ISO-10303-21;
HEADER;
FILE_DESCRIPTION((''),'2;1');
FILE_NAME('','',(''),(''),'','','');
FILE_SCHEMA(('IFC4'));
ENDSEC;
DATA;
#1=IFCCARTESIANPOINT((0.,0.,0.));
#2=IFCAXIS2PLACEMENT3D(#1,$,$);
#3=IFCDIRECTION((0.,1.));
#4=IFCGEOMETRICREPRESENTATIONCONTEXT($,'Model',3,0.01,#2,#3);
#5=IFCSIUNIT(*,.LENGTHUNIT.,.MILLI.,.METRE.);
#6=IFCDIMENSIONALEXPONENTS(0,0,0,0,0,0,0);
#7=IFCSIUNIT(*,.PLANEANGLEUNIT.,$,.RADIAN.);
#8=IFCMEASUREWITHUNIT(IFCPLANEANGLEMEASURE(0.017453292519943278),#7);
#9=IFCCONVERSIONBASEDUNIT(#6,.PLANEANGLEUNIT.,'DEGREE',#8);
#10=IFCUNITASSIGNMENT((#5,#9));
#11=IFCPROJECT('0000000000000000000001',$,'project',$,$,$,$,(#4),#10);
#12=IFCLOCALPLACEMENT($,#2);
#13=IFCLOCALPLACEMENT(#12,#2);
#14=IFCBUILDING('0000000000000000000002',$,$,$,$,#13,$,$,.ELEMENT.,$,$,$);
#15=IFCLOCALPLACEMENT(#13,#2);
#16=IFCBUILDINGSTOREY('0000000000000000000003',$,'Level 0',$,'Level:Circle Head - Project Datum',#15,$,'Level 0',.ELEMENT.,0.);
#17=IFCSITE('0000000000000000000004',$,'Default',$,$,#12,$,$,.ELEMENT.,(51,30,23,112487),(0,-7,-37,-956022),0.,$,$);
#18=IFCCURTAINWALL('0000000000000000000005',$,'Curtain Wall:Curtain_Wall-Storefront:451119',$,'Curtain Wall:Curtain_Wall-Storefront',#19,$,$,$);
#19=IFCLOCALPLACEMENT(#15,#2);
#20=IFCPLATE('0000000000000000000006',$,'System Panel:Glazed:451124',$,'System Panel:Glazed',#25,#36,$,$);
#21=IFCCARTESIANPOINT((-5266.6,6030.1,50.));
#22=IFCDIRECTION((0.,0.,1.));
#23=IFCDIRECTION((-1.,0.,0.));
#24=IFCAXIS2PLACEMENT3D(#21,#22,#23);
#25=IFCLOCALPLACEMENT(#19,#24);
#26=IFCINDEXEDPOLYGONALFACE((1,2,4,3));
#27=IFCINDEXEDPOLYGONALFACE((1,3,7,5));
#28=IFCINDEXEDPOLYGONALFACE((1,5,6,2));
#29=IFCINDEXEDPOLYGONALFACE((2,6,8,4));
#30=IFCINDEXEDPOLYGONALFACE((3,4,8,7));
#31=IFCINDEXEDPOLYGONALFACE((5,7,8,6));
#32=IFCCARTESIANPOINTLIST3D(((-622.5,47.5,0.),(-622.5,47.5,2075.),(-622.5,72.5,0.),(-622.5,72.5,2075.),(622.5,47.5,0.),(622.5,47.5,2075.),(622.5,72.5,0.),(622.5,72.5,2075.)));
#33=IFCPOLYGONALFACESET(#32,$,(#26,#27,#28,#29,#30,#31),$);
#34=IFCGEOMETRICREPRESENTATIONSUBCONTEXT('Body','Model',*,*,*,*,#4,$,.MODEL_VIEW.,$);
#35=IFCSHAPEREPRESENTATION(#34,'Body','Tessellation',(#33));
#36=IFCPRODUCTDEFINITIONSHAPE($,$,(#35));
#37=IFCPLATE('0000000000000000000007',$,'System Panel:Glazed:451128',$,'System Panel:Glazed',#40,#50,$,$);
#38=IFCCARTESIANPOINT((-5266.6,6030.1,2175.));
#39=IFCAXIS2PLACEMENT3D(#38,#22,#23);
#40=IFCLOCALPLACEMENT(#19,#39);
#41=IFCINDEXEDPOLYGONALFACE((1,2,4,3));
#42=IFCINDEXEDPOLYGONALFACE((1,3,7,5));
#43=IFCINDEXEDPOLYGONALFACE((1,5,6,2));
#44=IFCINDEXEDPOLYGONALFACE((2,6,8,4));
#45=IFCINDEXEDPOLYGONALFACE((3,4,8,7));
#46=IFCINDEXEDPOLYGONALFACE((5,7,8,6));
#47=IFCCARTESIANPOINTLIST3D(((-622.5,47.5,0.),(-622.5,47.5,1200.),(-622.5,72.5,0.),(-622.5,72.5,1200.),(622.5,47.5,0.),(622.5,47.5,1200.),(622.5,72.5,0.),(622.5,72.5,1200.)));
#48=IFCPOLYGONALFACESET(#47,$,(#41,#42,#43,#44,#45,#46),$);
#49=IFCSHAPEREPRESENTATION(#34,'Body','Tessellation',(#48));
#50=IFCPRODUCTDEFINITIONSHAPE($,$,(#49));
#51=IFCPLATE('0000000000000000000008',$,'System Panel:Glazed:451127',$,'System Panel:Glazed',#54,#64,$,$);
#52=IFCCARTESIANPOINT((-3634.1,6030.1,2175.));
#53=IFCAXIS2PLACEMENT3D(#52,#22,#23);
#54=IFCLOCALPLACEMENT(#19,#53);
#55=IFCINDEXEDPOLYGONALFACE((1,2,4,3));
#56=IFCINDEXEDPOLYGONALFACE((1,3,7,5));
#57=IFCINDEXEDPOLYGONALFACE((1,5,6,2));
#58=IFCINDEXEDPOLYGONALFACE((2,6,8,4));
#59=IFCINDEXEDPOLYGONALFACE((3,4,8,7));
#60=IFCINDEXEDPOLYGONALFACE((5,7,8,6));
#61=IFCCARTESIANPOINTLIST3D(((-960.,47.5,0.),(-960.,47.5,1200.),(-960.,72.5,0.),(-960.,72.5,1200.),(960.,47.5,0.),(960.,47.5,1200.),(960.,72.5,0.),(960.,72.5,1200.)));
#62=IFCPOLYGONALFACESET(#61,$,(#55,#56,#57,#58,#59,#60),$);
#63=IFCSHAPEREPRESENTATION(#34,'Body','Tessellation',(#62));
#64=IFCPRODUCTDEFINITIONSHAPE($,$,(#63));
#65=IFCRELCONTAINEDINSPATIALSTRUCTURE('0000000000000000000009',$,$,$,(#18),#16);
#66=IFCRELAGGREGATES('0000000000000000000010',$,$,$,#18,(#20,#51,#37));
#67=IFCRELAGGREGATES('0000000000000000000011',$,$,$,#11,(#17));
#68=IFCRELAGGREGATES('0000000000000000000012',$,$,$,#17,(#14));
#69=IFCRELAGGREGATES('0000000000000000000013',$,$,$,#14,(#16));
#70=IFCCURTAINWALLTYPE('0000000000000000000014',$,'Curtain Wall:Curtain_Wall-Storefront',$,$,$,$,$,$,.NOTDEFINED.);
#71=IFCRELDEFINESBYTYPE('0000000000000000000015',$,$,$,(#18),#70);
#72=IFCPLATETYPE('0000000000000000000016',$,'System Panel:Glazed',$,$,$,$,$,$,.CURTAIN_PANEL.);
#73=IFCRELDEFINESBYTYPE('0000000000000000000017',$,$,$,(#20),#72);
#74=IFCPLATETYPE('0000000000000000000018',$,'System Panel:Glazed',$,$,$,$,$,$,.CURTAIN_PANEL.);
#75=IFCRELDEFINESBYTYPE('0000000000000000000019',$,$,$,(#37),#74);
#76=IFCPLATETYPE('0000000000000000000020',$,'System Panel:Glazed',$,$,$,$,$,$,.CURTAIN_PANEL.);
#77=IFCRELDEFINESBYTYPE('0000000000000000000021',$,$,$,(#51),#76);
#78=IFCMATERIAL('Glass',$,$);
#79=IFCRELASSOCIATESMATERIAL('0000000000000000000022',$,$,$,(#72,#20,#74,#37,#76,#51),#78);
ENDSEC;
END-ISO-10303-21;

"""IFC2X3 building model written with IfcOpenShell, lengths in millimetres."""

from ifc_helpers import new_model, entity, si_unit, converted_unit, direction, frame, origin, origin_2d_with_axis, place, context, subcontext, project, spatial, rectangle, extrude, source, transform, mapped, material, type_object, type_shapes, element, aggregate, save


model = new_model("IFC2X3")

# Units and contexts
model_context = context("Model", 3, precision=0.01, world=origin(), true_north=direction((0.0, 1.0)))
body_context = subcontext(model_context, "Body", "Model", "MODEL_VIEW")
ifc_project = project(units=[si_unit("LENGTHUNIT", "METRE", prefix="MILLI"), converted_unit("PLANEANGLEUNIT", "DEGREE", entity("IfcPlaneAngleMeasure", 0.017453292519943278), si_unit("PLANEANGLEUNIT", "RADIAN"), dimensions=[0, 0, 0, 0, 0, 0, 0])], contexts=[model_context])

# Site, building, storey
site_placement = place(None, origin())
site = spatial("IfcSite", under=ifc_project, at=site_placement, Name="Default", CompositionType="ELEMENT", RefLatitude=(51, 30, 23, 112487), RefLongitude=(0, -7, -37, -956022), RefElevation=0.0)
building_placement = place(site_placement, origin())
building = spatial("IfcBuilding", under=site, at=building_placement, CompositionType="ELEMENT")
storey_placement = place(building_placement, origin())
storey = spatial("IfcBuildingStorey", under=building, at=storey_placement, Name="Level 0", ObjectType="Level:Circle Head - Project Datum", LongName="Level 0", CompositionType="ELEMENT", Elevation=0.0)

# Curtain wall
curtain_wall_type = type_object("IfcCurtainWallType", Name="Curtain Wall:Curtain_Wall-Storefront", PredefinedType="NOTDEFINED")
curtain_wall_1_placement = place(storey_placement, origin())
curtain_wall_1 = element("IfcCurtainWall", 1, at=curtain_wall_1_placement, inside=storey, type_object=curtain_wall_type, Name="Curtain Wall:Curtain_Wall-Storefront:451119", ObjectType="Curtain Wall:Curtain_Wall-Storefront")

# Plates
ifc_material_1 = material(Name="Glass")
plate_type_1 = type_object("IfcPlateType", Name="System Panel:Glazed", PredefinedType="CURTAIN_PANEL", material=ifc_material_1)
shared_shape_1 = source(origin(), body_context, "Body", "SweptSolid", [
    extrude(rectangle(XDim=25.0, YDim=1245.0, at=origin_2d_with_axis()), frame((0.0, 60.0, 0.0), z_axis=(0.0, 0.0, 1.0), x_axis=(0.0, 1.0, 0.0)), (0.0, 0.0, 1.0), 2075.0),
])
type_shapes(plate_type_1, [shared_shape_1])
plate_1_placement = place(curtain_wall_1_placement, frame((-5266.6, 6030.1, 50.0), z_axis=(0.0, 0.0, 1.0), x_axis=(-1.0, 0.0, 0.0)))
plate_1 = element("IfcPlate", 2, at=plate_1_placement, type_object=plate_type_1, material=ifc_material_1, Name="System Panel:Glazed:451124", ObjectType="System Panel:Glazed", context=body_context, shape_type="MappedRepresentation", body=[
    mapped(shared_shape_1, transform((0.0, 0.0, 0.0), scale=1.0)),
])
plate_type_2 = type_object("IfcPlateType", Name="System Panel:Glazed", PredefinedType="CURTAIN_PANEL", material=ifc_material_1)
shared_shape_2 = source(origin(), body_context, "Body", "SweptSolid", [
    extrude(rectangle(XDim=25.0, YDim=1245.0, at=origin_2d_with_axis()), frame((0.0, 60.0, 0.0), z_axis=(0.0, 0.0, 1.0), x_axis=(0.0, 1.0, 0.0)), (0.0, 0.0, 1.0), 1200.0),
])
type_shapes(plate_type_2, [shared_shape_2])
plate_2_placement = place(curtain_wall_1_placement, frame((-5266.6, 6030.1, 2175.0), z_axis=(0.0, 0.0, 1.0), x_axis=(-1.0, 0.0, 0.0)))
plate_2 = element("IfcPlate", 3, at=plate_2_placement, type_object=plate_type_2, material=ifc_material_1, Name="System Panel:Glazed:451128", ObjectType="System Panel:Glazed", context=body_context, shape_type="MappedRepresentation", body=[
    mapped(shared_shape_2, transform((0.0, 0.0, 0.0), scale=1.0)),
])
plate_type_3 = type_object("IfcPlateType", Name="System Panel:Glazed", PredefinedType="CURTAIN_PANEL", material=ifc_material_1)
shared_shape_3 = source(origin(), body_context, "Body", "SweptSolid", [
    extrude(rectangle(XDim=25.0, YDim=1920.0, at=origin_2d_with_axis()), frame((0.0, 60.0, 0.0), z_axis=(0.0, 0.0, 1.0), x_axis=(0.0, 1.0, 0.0)), (0.0, 0.0, 1.0), 1200.0),
])
type_shapes(plate_type_3, [shared_shape_3])
plate_3_placement = place(curtain_wall_1_placement, frame((-3634.1, 6030.1, 2175.0), z_axis=(0.0, 0.0, 1.0), x_axis=(-1.0, 0.0, 0.0)))
plate_3 = element("IfcPlate", 4, at=plate_3_placement, type_object=plate_type_3, material=ifc_material_1, Name="System Panel:Glazed:451127", ObjectType="System Panel:Glazed", context=body_context, shape_type="MappedRepresentation", body=[
    mapped(shared_shape_3, transform((0.0, 0.0, 0.0), scale=1.0)),
])
aggregate(curtain_wall_1, [plate_1, plate_3, plate_2])

save(model, "model.ifc")
